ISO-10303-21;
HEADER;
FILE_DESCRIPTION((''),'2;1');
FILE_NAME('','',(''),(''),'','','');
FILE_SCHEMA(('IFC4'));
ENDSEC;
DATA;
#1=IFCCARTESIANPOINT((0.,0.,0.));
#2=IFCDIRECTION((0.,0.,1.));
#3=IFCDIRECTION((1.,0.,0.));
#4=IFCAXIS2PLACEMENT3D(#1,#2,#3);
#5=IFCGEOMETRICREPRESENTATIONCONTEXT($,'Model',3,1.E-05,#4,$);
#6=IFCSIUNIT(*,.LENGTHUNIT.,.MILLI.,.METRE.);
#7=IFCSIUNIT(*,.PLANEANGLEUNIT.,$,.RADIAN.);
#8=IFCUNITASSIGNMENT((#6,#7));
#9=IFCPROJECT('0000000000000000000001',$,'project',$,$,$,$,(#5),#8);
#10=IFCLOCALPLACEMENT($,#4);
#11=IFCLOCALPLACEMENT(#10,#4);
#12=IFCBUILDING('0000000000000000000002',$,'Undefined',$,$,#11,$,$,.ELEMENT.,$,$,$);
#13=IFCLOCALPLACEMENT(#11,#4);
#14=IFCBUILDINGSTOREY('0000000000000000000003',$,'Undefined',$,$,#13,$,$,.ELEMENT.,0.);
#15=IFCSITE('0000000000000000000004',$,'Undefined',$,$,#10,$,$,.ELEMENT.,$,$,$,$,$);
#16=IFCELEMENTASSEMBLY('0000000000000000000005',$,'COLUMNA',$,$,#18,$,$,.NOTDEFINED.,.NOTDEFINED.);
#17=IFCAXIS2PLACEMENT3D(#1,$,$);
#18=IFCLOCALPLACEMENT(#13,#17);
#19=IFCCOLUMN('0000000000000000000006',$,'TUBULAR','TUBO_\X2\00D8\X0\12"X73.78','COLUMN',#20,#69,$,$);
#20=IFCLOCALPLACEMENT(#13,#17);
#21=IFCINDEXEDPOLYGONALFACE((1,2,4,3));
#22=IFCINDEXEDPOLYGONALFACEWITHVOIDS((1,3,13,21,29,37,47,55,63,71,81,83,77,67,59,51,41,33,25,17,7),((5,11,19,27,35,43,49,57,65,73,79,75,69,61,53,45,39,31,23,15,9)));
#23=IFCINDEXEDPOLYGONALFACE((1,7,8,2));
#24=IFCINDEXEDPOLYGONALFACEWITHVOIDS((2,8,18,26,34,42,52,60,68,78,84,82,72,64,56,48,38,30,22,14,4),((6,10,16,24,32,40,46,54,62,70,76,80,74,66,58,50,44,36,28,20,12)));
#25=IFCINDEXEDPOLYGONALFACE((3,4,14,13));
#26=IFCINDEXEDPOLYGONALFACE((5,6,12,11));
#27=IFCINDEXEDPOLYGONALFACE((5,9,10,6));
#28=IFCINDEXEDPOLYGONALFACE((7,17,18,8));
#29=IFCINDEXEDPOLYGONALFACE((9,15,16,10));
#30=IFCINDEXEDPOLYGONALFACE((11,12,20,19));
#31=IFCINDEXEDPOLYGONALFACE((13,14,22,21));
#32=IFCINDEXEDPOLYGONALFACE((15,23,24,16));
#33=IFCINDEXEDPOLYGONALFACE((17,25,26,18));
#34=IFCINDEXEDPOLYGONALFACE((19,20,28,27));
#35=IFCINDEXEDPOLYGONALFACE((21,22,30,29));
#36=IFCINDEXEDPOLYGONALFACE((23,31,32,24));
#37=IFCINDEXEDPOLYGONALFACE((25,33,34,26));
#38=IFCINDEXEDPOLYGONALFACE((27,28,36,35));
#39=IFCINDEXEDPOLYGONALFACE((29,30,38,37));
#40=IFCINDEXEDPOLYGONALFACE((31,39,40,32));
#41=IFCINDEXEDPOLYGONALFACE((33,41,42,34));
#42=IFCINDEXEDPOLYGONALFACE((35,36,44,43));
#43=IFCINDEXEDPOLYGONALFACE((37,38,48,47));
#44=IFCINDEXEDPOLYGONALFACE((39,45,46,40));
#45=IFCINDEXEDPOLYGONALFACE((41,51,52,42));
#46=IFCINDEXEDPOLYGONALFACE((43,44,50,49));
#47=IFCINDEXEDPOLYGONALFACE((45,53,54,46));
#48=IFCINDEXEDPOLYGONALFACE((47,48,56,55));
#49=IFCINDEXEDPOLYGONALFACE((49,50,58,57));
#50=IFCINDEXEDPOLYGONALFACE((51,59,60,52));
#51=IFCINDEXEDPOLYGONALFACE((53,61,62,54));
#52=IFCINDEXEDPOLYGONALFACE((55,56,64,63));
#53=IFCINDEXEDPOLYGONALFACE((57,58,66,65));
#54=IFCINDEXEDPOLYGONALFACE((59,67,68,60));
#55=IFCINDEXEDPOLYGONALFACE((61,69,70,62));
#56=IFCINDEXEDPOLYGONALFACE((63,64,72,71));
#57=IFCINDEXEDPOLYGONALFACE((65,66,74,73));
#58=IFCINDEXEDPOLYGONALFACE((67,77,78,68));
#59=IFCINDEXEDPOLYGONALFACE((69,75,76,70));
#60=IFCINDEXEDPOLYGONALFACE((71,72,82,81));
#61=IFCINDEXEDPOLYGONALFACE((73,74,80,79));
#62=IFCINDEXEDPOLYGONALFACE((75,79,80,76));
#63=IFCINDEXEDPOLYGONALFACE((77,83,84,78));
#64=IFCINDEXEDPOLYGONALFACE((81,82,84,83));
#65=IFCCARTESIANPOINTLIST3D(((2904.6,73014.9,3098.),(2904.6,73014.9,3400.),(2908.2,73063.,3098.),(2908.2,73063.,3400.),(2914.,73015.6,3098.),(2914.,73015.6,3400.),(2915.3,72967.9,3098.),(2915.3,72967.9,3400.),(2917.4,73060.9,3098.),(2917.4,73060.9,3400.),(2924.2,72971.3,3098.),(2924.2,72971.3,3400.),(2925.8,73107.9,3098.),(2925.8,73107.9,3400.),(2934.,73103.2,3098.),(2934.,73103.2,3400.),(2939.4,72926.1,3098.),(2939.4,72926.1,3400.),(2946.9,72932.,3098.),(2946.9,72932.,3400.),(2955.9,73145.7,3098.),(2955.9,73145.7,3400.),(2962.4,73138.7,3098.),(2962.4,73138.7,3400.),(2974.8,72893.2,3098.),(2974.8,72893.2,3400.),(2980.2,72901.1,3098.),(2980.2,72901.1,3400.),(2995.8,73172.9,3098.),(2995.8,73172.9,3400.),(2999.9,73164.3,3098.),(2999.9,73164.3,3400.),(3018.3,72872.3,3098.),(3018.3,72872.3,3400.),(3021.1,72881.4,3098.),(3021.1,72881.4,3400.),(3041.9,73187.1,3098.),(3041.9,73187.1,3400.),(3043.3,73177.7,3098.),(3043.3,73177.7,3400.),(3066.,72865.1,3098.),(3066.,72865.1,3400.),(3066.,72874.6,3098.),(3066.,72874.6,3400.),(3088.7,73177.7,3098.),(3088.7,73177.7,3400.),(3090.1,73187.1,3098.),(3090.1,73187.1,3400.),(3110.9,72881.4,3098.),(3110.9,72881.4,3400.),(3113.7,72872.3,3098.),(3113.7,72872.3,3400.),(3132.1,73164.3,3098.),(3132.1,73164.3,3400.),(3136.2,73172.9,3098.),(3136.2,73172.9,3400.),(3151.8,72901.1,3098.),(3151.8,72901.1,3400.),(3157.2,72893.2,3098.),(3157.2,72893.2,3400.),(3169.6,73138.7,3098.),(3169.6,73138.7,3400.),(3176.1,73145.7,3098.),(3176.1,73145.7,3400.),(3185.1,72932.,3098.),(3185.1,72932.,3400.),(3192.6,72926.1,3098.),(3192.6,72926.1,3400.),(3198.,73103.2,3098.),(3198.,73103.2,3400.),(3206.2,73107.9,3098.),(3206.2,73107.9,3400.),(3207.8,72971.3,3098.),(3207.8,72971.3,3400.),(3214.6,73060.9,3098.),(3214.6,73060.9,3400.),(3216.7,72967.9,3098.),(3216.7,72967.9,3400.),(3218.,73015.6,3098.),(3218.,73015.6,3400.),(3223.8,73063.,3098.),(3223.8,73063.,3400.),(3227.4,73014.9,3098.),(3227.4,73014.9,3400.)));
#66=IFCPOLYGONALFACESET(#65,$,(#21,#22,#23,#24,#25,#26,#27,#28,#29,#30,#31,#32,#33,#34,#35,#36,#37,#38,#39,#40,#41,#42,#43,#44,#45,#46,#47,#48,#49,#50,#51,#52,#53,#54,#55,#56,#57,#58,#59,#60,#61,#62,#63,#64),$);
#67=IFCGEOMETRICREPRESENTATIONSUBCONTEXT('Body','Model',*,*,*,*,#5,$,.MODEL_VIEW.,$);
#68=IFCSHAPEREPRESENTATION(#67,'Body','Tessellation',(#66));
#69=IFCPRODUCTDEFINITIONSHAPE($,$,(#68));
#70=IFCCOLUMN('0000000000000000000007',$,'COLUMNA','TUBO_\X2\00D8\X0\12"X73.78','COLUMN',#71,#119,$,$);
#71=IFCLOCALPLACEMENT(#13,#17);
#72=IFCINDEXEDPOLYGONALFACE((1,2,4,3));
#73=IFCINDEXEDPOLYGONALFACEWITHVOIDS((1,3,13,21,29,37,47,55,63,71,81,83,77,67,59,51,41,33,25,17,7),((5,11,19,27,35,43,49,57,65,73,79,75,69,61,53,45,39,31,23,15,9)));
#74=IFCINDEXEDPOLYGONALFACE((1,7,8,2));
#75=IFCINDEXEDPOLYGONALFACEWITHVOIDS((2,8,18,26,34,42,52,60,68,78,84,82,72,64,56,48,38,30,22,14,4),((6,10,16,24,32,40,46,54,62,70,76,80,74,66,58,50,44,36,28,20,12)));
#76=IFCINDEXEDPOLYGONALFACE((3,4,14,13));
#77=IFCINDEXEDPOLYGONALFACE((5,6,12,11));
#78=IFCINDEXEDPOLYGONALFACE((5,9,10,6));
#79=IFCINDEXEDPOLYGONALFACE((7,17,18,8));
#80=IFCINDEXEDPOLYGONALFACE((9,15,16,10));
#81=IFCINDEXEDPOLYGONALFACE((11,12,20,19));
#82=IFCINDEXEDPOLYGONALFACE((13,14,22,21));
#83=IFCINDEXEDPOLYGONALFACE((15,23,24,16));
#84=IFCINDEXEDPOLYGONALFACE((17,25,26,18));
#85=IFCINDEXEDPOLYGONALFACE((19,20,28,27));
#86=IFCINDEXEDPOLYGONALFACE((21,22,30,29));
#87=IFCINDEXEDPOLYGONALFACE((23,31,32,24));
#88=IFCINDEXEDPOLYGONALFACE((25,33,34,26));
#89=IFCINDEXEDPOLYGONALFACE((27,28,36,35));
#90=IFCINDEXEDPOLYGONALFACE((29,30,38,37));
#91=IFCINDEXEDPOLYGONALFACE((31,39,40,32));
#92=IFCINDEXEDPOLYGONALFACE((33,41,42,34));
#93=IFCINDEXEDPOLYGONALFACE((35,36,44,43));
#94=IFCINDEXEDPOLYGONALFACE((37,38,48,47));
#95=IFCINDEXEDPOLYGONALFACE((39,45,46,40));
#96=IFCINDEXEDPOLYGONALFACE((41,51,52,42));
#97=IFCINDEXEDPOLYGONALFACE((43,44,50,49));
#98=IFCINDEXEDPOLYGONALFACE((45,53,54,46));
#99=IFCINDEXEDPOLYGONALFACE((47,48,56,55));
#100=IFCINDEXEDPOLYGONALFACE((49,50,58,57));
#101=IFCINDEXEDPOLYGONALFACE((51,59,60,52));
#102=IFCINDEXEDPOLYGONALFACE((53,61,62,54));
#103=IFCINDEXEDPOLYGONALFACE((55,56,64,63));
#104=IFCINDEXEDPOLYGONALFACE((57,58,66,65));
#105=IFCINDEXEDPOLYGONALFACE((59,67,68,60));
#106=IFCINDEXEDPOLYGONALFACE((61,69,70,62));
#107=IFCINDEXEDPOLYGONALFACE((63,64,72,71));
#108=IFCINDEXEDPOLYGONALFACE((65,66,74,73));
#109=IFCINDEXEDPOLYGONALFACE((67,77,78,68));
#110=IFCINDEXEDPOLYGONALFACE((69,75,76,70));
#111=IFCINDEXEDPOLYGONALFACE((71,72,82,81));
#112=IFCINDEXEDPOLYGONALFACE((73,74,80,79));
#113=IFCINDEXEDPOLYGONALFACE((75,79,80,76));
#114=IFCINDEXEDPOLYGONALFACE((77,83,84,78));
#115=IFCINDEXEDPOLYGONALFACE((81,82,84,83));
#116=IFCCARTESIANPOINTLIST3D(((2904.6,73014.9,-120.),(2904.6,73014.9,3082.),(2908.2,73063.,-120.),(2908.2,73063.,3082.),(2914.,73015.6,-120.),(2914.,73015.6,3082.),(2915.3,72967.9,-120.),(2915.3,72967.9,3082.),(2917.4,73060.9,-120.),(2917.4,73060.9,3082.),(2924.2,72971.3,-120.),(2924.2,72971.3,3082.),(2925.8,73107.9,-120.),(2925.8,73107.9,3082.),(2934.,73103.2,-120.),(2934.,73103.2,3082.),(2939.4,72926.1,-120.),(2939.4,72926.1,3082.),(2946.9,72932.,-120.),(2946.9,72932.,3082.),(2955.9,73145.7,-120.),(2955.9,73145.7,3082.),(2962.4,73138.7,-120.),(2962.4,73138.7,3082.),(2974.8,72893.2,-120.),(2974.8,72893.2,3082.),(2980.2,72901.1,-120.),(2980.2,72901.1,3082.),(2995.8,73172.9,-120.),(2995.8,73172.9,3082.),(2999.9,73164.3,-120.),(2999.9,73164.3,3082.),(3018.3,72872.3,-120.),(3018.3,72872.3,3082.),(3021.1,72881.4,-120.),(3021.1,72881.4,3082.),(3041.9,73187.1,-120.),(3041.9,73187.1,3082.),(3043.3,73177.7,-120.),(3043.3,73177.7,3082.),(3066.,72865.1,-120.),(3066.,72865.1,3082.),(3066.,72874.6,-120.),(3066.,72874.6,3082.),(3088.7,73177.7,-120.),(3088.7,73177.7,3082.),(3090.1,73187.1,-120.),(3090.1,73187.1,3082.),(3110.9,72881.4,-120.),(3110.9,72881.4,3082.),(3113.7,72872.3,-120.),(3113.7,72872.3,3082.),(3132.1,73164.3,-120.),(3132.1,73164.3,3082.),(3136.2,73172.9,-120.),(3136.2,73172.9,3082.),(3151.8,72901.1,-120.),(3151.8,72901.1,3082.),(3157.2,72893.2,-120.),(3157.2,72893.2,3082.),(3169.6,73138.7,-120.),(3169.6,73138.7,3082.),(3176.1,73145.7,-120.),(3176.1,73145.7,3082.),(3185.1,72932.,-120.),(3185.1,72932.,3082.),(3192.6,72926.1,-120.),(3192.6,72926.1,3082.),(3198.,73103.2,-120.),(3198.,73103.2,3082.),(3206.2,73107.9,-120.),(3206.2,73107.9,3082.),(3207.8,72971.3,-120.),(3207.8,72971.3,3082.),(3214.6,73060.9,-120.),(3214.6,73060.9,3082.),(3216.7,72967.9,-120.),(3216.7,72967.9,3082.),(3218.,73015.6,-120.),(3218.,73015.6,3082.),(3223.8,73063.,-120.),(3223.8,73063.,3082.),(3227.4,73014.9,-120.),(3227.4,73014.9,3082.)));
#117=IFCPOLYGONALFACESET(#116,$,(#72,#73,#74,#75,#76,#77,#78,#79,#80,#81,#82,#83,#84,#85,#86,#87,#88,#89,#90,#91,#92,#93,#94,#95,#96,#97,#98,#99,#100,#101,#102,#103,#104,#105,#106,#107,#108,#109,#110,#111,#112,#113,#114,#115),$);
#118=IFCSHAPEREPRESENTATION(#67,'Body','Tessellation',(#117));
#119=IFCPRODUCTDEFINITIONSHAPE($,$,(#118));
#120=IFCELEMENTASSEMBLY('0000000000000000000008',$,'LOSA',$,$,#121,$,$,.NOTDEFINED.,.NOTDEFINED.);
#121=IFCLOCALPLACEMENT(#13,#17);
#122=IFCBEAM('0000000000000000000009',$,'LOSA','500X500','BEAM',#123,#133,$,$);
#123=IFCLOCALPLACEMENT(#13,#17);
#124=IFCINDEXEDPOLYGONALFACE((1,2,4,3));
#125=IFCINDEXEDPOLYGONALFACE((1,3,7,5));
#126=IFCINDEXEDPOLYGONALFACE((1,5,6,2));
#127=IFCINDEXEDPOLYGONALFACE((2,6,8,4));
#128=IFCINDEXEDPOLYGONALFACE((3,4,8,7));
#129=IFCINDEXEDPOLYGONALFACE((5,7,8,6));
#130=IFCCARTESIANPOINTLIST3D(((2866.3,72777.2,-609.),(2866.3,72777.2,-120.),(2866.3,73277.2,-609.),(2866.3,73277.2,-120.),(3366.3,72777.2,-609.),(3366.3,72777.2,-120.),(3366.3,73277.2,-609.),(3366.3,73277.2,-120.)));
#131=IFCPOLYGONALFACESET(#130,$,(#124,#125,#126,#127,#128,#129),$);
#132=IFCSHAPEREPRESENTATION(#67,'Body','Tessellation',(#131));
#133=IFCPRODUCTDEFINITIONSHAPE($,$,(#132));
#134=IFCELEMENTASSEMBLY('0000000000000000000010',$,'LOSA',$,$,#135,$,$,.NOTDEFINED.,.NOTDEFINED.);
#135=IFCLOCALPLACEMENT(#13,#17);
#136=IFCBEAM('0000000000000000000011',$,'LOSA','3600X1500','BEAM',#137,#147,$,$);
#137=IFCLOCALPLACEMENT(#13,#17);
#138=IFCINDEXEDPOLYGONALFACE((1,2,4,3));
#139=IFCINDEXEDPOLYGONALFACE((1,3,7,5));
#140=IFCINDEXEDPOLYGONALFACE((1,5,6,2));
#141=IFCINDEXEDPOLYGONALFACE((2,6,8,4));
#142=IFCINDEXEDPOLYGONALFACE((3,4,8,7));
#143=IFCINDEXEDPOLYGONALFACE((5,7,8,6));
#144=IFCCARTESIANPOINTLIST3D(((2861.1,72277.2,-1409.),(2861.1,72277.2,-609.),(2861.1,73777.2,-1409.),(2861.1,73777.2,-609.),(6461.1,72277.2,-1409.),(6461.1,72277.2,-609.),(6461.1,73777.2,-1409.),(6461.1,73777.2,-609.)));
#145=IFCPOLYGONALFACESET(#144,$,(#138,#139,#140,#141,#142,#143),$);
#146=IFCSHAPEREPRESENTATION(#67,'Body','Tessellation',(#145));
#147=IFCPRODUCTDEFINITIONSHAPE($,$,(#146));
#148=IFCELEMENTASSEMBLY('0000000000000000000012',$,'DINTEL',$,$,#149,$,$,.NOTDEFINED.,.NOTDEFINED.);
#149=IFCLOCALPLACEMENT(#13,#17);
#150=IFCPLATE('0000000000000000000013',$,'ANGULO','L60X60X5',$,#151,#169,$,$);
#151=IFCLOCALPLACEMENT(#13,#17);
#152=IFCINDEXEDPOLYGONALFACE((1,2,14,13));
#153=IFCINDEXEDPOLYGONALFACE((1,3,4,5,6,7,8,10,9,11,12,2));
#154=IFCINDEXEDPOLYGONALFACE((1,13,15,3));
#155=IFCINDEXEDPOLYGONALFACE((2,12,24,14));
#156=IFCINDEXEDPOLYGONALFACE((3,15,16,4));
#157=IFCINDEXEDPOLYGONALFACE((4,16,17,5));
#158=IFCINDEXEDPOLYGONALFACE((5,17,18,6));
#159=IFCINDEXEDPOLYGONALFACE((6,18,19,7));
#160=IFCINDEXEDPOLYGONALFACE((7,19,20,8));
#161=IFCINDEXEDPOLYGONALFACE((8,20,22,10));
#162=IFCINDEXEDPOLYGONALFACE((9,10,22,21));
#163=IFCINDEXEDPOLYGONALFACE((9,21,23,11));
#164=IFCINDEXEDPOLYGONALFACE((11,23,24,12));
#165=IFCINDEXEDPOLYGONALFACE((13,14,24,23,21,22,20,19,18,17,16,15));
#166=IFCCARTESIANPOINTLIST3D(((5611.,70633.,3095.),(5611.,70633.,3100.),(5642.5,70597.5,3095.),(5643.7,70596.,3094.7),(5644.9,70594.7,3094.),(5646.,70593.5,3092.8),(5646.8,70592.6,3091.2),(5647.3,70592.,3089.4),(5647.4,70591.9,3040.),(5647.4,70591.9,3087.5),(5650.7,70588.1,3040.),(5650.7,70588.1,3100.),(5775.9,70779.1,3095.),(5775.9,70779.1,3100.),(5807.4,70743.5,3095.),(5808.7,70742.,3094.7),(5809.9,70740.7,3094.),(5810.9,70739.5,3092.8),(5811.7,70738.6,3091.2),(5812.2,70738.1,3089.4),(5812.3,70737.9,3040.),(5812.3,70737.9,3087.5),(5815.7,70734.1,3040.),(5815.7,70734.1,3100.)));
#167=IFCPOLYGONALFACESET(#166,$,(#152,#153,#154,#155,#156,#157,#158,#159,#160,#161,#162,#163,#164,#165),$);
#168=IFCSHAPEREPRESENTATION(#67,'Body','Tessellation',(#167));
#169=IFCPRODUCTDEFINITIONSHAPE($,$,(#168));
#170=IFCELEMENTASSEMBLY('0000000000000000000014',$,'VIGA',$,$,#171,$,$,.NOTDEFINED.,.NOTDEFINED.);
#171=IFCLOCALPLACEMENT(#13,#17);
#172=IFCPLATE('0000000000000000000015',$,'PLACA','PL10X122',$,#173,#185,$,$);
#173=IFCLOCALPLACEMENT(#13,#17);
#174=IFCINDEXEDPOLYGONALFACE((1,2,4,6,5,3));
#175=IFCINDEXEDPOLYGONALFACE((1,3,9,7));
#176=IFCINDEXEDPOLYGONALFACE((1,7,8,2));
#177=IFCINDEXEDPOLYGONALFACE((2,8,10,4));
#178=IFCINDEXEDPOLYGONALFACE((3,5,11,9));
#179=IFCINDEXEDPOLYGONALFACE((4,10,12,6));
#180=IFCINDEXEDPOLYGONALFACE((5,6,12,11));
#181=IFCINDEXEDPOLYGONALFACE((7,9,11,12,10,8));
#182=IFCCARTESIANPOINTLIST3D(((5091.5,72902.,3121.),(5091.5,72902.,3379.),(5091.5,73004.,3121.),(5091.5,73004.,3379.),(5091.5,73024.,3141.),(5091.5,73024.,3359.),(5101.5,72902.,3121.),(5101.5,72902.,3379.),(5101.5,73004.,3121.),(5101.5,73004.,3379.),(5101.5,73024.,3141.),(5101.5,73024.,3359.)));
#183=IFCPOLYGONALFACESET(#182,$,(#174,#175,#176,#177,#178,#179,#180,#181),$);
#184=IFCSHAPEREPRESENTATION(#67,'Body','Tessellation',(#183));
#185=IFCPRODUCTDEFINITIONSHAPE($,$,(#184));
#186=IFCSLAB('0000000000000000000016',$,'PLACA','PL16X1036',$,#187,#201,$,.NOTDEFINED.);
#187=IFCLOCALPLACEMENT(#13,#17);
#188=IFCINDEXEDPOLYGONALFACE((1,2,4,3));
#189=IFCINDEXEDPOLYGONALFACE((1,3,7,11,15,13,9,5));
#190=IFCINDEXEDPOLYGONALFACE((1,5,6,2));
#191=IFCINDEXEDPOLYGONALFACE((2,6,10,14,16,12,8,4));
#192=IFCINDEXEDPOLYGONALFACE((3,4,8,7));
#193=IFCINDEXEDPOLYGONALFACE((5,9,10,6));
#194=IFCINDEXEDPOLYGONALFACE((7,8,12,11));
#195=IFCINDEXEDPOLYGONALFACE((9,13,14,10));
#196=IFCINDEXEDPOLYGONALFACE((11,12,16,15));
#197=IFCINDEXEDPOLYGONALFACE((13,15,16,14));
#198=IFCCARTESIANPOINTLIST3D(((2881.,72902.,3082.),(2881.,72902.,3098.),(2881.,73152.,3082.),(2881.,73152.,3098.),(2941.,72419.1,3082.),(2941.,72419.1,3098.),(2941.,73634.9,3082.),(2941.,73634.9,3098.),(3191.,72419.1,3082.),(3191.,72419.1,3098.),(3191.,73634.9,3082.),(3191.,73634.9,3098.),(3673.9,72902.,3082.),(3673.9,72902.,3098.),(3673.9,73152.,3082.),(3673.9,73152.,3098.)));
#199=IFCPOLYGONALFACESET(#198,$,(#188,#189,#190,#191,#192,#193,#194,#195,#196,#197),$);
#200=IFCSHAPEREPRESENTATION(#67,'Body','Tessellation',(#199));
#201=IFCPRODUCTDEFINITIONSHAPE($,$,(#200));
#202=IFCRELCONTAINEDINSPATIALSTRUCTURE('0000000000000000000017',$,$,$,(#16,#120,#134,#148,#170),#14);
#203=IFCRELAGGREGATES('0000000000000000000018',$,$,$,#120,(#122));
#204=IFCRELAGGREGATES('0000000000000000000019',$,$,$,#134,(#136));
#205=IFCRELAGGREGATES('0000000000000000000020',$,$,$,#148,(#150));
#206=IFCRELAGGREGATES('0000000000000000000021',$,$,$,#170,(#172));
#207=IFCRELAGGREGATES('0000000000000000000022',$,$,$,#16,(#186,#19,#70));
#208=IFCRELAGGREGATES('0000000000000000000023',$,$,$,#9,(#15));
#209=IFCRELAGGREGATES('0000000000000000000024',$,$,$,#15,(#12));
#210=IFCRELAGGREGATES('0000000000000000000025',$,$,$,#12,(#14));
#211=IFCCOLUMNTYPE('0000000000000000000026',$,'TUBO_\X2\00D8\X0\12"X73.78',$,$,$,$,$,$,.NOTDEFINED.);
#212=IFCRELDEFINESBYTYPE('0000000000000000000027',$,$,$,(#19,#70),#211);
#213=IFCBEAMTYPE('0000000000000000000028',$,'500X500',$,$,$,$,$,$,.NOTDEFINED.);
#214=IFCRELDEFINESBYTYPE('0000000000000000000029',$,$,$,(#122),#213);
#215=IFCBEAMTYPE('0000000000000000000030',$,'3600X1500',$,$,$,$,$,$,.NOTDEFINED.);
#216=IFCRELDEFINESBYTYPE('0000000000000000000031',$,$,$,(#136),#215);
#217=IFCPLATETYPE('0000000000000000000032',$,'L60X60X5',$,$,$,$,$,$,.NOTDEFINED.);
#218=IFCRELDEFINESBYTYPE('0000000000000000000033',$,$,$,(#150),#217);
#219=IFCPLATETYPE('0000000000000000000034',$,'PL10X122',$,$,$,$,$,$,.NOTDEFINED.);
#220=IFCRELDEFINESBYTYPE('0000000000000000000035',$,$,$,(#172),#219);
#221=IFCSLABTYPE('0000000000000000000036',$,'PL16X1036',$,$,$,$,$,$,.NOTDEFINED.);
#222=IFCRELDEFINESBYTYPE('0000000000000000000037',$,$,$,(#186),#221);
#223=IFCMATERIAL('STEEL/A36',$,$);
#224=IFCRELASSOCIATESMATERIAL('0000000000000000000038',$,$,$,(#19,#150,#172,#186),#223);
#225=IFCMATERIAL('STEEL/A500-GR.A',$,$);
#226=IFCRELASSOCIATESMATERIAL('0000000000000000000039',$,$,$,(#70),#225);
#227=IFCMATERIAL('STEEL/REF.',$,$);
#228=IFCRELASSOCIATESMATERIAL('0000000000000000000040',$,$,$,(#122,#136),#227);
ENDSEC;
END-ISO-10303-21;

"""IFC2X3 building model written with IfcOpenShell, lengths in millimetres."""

from ifc_helpers import new_model, si_unit, frame, origin_with_axes, origin_2d_with_axis, place, context, subcontext, project, spatial, polyline, rectangle, hollow_circle, l_section, outline, extrude, material, type_object, element, aggregate, save


model = new_model("IFC2X3")

# Units and contexts
model_context = context("Model", 3, precision=1e-05, world=origin_with_axes())
body_context = subcontext(model_context, "Body", "Model", "MODEL_VIEW")
ifc_project = project(units=[si_unit("LENGTHUNIT", "METRE", prefix="MILLI"), si_unit("PLANEANGLEUNIT", "RADIAN")], contexts=[model_context])

# Site, building, storey
site_placement = place(None, origin_with_axes())
site = spatial("IfcSite", under=ifc_project, at=site_placement, Name="Undefined", CompositionType="ELEMENT")
building_placement = place(site_placement, origin_with_axes())
building = spatial("IfcBuilding", under=site, at=building_placement, Name="Undefined", CompositionType="ELEMENT")
storey_placement = place(building_placement, origin_with_axes())
storey = spatial("IfcBuildingStorey", under=building, at=storey_placement, Name="Undefined", CompositionType="ELEMENT", Elevation=0.0)

# Element assembly, columns
assembly_1_placement = place(storey_placement, origin_with_axes())
assembly_1 = element("IfcElementAssembly", 1, at=assembly_1_placement, inside=storey, Name="COLUMNA", AssemblyPlace="NOTDEFINED", PredefinedType="NOTDEFINED")
ifc_material_1 = material(Name="STEEL/A36")
column_type = type_object("IfcColumnType", Name="TUBO_Ø12\"X73.78", PredefinedType="NOTDEFINED")
column_1_placement = place(assembly_1_placement, frame((3066.0, 73027.0, 3098.0), z_axis=(0.0, 0.0, 1.0), x_axis=(-1.0, 0.0, 0.0)))
column_1 = element("IfcColumn", 2, at=column_1_placement, type_object=column_type, material=ifc_material_1, Name="TUBULAR", Description="TUBO_Ø12\"X73.78", ObjectType="COLUMN", context=body_context, shape_type="SweptSolid", body=[
    extrude(hollow_circle(Radius=161.9, WallThickness=9.5, at=origin_2d_with_axis()), frame((0.0, 0.0, 302.0), z_axis=(0.0, 0.0, -1.0), x_axis=(0.0, 1.0, 0.0)), (0.0, 0.0, 1.0), 302.0),
])
ifc_material_2 = material(Name="STEEL/A500-GR.A")
column_2_placement = place(assembly_1_placement, frame((3066.0, 73027.0, -120.0), z_axis=(0.0, 0.0, 1.0), x_axis=(-1.0, 0.0, 0.0)))
column_2 = element("IfcColumn", 3, at=column_2_placement, type_object=column_type, material=ifc_material_2, Name="COLUMNA", Description="TUBO_Ø12\"X73.78", ObjectType="COLUMN", context=body_context, shape_type="SweptSolid", body=[
    extrude(hollow_circle(Radius=161.9, WallThickness=9.5, at=origin_2d_with_axis()), frame((0.0, 0.0, 3202.0), z_axis=(0.0, 0.0, -1.0), x_axis=(0.0, 1.0, 0.0)), (0.0, 0.0, 1.0), 3202.0),
])

# Element assemblies, beams
assembly_2_placement = place(storey_placement, origin_with_axes())
assembly_2 = element("IfcElementAssembly", 4, at=assembly_2_placement, inside=storey, Name="LOSA", AssemblyPlace="NOTDEFINED", PredefinedType="NOTDEFINED")
ifc_material_3 = material(Name="STEEL/REF.")
beam_type_1 = type_object("IfcBeamType", Name="500X500", PredefinedType="NOTDEFINED")
beam_1_placement = place(assembly_2_placement, frame((3116.3, 73027.2, -120.0), z_axis=(1.0, 0.0, 0.0), x_axis=(0.0, 0.0, -1.0)))
beam_1 = element("IfcBeam", 5, at=beam_1_placement, type_object=beam_type_1, material=ifc_material_3, Name="LOSA", Description="500X500", ObjectType="BEAM", context=body_context, shape_type="SweptSolid", body=[
    extrude(rectangle(XDim=500.0, YDim=500.0, at=origin_2d_with_axis()), frame((489.0, 0.0, 0.0), z_axis=(-1.0, 0.0, 0.0), x_axis=(0.0, -1.0, 0.0)), (0.0, 0.0, 1.0), 489.0),
])
aggregate(assembly_2, [beam_1])
assembly_3_placement = place(storey_placement, origin_with_axes())
assembly_3 = element("IfcElementAssembly", 6, at=assembly_3_placement, inside=storey, Name="LOSA", AssemblyPlace="NOTDEFINED", PredefinedType="NOTDEFINED")
beam_type_2 = type_object("IfcBeamType", Name="3600X1500", PredefinedType="NOTDEFINED")
beam_2_placement = place(assembly_3_placement, frame((4661.1, 73027.2, -609.0), z_axis=(1.0, 0.0, 0.0), x_axis=(0.0, 0.0, -1.0)))
beam_2 = element("IfcBeam", 7, at=beam_2_placement, type_object=beam_type_2, material=ifc_material_3, Name="LOSA", Description="3600X1500", ObjectType="BEAM", context=body_context, shape_type="SweptSolid", body=[
    extrude(rectangle(XDim=1500.0, YDim=3600.0, at=origin_2d_with_axis()), frame((800.0, 0.0, 0.0), z_axis=(-1.0, 0.0, 0.0), x_axis=(0.0, -1.0, 0.0)), (0.0, 0.0, 1.0), 800.0),
])
aggregate(assembly_3, [beam_2])

# Element assemblies, plates
assembly_4_placement = place(storey_placement, origin_with_axes())
assembly_4 = element("IfcElementAssembly", 8, at=assembly_4_placement, inside=storey, Name="DINTEL", AssemblyPlace="NOTDEFINED", PredefinedType="NOTDEFINED")
plate_type_1 = type_object("IfcPlateType", Name="L60X60X5", PredefinedType="NOTDEFINED")
plate_1_placement = place(assembly_4_placement, frame((5630.9, 70610.6, 3070.0), z_axis=(0.0, 0.0, -1.0), x_axis=(0.748701, 0.662908, 0.0)))
plate_1 = element("IfcPlate", 9, at=plate_1_placement, type_object=plate_type_1, material=ifc_material_1, Name="ANGULO", Description="L60X60X5", context=body_context, shape_type="SweptSolid", body=[
    extrude(l_section(Depth=60.0, Width=60.0, Thickness=5.0, FilletRadius=7.5, at=origin_2d_with_axis()), frame((220.3, 0.0, 0.0), z_axis=(-1.0, 0.0, 0.0), x_axis=(0.0, -1.0, 0.0)), (0.0, 0.0, 1.0), 220.3),
])
aggregate(assembly_4, [plate_1])
assembly_5_placement = place(storey_placement, origin_with_axes())
assembly_5 = element("IfcElementAssembly", 10, at=assembly_5_placement, inside=storey, Name="VIGA", AssemblyPlace="NOTDEFINED", PredefinedType="NOTDEFINED")
plate_type_2 = type_object("IfcPlateType", Name="PL10X122", PredefinedType="NOTDEFINED")
plate_2_placement = place(assembly_5_placement, frame((5096.5, 73024.0, 3121.0), z_axis=(-1.0, 0.0, 0.0), x_axis=(0.0, -1.0, 0.0)))
plate_2 = element("IfcPlate", 11, at=plate_2_placement, type_object=plate_type_2, material=ifc_material_1, Name="PLACA", Description="PL10X122", context=body_context, shape_type="SweptSolid", body=[
    extrude(outline(polyline([(0.0, 20.0), (20.0, 0.0), (122.0, 0.0), (122.0, 258.0), (20.0, 258.0), (0.0, 238.0), (0.0, 20.0)])), frame((0.0, 0.0, -5.0), z_axis=(0.0, 0.0, 1.0), x_axis=(1.0, 0.0, 0.0)), (0.0, 0.0, 1.0), 10.0),
])
aggregate(assembly_5, [plate_2])

# Slab
slab_type_1 = type_object("IfcSlabType", Name="PL16X1036", PredefinedType="NOTDEFINED")
slab_1_placement = place(assembly_1_placement, frame((3191.0, 72419.1, 3090.0), z_axis=(0.0, 0.0, 1.0), x_axis=(0.707107, 0.707107, 0.0)))
slab_1 = element("IfcSlab", 12, at=slab_1_placement, type_object=slab_type_1, material=ifc_material_1, Name="PLACA", Description="PL16X1036", PredefinedType="NOTDEFINED", context=body_context, shape_type="SweptSolid", body=[
    extrude(outline(polyline([(0.0, 0.0), (682.9, 0.0), (859.7, 176.8), (859.7, 859.7), (682.9, 1036.5), (299.0, 737.4), (122.3, 560.7), (-176.8, 176.8), (0.0, 0.0)])), frame((0.0, 0.0, -8.0), z_axis=(0.0, 0.0, 1.0), x_axis=(1.0, 0.0, 0.0)), (0.0, 0.0, 1.0), 16.0),
])

aggregate(assembly_1, [slab_1, column_1, column_2])

save(model, "model.ifc")
